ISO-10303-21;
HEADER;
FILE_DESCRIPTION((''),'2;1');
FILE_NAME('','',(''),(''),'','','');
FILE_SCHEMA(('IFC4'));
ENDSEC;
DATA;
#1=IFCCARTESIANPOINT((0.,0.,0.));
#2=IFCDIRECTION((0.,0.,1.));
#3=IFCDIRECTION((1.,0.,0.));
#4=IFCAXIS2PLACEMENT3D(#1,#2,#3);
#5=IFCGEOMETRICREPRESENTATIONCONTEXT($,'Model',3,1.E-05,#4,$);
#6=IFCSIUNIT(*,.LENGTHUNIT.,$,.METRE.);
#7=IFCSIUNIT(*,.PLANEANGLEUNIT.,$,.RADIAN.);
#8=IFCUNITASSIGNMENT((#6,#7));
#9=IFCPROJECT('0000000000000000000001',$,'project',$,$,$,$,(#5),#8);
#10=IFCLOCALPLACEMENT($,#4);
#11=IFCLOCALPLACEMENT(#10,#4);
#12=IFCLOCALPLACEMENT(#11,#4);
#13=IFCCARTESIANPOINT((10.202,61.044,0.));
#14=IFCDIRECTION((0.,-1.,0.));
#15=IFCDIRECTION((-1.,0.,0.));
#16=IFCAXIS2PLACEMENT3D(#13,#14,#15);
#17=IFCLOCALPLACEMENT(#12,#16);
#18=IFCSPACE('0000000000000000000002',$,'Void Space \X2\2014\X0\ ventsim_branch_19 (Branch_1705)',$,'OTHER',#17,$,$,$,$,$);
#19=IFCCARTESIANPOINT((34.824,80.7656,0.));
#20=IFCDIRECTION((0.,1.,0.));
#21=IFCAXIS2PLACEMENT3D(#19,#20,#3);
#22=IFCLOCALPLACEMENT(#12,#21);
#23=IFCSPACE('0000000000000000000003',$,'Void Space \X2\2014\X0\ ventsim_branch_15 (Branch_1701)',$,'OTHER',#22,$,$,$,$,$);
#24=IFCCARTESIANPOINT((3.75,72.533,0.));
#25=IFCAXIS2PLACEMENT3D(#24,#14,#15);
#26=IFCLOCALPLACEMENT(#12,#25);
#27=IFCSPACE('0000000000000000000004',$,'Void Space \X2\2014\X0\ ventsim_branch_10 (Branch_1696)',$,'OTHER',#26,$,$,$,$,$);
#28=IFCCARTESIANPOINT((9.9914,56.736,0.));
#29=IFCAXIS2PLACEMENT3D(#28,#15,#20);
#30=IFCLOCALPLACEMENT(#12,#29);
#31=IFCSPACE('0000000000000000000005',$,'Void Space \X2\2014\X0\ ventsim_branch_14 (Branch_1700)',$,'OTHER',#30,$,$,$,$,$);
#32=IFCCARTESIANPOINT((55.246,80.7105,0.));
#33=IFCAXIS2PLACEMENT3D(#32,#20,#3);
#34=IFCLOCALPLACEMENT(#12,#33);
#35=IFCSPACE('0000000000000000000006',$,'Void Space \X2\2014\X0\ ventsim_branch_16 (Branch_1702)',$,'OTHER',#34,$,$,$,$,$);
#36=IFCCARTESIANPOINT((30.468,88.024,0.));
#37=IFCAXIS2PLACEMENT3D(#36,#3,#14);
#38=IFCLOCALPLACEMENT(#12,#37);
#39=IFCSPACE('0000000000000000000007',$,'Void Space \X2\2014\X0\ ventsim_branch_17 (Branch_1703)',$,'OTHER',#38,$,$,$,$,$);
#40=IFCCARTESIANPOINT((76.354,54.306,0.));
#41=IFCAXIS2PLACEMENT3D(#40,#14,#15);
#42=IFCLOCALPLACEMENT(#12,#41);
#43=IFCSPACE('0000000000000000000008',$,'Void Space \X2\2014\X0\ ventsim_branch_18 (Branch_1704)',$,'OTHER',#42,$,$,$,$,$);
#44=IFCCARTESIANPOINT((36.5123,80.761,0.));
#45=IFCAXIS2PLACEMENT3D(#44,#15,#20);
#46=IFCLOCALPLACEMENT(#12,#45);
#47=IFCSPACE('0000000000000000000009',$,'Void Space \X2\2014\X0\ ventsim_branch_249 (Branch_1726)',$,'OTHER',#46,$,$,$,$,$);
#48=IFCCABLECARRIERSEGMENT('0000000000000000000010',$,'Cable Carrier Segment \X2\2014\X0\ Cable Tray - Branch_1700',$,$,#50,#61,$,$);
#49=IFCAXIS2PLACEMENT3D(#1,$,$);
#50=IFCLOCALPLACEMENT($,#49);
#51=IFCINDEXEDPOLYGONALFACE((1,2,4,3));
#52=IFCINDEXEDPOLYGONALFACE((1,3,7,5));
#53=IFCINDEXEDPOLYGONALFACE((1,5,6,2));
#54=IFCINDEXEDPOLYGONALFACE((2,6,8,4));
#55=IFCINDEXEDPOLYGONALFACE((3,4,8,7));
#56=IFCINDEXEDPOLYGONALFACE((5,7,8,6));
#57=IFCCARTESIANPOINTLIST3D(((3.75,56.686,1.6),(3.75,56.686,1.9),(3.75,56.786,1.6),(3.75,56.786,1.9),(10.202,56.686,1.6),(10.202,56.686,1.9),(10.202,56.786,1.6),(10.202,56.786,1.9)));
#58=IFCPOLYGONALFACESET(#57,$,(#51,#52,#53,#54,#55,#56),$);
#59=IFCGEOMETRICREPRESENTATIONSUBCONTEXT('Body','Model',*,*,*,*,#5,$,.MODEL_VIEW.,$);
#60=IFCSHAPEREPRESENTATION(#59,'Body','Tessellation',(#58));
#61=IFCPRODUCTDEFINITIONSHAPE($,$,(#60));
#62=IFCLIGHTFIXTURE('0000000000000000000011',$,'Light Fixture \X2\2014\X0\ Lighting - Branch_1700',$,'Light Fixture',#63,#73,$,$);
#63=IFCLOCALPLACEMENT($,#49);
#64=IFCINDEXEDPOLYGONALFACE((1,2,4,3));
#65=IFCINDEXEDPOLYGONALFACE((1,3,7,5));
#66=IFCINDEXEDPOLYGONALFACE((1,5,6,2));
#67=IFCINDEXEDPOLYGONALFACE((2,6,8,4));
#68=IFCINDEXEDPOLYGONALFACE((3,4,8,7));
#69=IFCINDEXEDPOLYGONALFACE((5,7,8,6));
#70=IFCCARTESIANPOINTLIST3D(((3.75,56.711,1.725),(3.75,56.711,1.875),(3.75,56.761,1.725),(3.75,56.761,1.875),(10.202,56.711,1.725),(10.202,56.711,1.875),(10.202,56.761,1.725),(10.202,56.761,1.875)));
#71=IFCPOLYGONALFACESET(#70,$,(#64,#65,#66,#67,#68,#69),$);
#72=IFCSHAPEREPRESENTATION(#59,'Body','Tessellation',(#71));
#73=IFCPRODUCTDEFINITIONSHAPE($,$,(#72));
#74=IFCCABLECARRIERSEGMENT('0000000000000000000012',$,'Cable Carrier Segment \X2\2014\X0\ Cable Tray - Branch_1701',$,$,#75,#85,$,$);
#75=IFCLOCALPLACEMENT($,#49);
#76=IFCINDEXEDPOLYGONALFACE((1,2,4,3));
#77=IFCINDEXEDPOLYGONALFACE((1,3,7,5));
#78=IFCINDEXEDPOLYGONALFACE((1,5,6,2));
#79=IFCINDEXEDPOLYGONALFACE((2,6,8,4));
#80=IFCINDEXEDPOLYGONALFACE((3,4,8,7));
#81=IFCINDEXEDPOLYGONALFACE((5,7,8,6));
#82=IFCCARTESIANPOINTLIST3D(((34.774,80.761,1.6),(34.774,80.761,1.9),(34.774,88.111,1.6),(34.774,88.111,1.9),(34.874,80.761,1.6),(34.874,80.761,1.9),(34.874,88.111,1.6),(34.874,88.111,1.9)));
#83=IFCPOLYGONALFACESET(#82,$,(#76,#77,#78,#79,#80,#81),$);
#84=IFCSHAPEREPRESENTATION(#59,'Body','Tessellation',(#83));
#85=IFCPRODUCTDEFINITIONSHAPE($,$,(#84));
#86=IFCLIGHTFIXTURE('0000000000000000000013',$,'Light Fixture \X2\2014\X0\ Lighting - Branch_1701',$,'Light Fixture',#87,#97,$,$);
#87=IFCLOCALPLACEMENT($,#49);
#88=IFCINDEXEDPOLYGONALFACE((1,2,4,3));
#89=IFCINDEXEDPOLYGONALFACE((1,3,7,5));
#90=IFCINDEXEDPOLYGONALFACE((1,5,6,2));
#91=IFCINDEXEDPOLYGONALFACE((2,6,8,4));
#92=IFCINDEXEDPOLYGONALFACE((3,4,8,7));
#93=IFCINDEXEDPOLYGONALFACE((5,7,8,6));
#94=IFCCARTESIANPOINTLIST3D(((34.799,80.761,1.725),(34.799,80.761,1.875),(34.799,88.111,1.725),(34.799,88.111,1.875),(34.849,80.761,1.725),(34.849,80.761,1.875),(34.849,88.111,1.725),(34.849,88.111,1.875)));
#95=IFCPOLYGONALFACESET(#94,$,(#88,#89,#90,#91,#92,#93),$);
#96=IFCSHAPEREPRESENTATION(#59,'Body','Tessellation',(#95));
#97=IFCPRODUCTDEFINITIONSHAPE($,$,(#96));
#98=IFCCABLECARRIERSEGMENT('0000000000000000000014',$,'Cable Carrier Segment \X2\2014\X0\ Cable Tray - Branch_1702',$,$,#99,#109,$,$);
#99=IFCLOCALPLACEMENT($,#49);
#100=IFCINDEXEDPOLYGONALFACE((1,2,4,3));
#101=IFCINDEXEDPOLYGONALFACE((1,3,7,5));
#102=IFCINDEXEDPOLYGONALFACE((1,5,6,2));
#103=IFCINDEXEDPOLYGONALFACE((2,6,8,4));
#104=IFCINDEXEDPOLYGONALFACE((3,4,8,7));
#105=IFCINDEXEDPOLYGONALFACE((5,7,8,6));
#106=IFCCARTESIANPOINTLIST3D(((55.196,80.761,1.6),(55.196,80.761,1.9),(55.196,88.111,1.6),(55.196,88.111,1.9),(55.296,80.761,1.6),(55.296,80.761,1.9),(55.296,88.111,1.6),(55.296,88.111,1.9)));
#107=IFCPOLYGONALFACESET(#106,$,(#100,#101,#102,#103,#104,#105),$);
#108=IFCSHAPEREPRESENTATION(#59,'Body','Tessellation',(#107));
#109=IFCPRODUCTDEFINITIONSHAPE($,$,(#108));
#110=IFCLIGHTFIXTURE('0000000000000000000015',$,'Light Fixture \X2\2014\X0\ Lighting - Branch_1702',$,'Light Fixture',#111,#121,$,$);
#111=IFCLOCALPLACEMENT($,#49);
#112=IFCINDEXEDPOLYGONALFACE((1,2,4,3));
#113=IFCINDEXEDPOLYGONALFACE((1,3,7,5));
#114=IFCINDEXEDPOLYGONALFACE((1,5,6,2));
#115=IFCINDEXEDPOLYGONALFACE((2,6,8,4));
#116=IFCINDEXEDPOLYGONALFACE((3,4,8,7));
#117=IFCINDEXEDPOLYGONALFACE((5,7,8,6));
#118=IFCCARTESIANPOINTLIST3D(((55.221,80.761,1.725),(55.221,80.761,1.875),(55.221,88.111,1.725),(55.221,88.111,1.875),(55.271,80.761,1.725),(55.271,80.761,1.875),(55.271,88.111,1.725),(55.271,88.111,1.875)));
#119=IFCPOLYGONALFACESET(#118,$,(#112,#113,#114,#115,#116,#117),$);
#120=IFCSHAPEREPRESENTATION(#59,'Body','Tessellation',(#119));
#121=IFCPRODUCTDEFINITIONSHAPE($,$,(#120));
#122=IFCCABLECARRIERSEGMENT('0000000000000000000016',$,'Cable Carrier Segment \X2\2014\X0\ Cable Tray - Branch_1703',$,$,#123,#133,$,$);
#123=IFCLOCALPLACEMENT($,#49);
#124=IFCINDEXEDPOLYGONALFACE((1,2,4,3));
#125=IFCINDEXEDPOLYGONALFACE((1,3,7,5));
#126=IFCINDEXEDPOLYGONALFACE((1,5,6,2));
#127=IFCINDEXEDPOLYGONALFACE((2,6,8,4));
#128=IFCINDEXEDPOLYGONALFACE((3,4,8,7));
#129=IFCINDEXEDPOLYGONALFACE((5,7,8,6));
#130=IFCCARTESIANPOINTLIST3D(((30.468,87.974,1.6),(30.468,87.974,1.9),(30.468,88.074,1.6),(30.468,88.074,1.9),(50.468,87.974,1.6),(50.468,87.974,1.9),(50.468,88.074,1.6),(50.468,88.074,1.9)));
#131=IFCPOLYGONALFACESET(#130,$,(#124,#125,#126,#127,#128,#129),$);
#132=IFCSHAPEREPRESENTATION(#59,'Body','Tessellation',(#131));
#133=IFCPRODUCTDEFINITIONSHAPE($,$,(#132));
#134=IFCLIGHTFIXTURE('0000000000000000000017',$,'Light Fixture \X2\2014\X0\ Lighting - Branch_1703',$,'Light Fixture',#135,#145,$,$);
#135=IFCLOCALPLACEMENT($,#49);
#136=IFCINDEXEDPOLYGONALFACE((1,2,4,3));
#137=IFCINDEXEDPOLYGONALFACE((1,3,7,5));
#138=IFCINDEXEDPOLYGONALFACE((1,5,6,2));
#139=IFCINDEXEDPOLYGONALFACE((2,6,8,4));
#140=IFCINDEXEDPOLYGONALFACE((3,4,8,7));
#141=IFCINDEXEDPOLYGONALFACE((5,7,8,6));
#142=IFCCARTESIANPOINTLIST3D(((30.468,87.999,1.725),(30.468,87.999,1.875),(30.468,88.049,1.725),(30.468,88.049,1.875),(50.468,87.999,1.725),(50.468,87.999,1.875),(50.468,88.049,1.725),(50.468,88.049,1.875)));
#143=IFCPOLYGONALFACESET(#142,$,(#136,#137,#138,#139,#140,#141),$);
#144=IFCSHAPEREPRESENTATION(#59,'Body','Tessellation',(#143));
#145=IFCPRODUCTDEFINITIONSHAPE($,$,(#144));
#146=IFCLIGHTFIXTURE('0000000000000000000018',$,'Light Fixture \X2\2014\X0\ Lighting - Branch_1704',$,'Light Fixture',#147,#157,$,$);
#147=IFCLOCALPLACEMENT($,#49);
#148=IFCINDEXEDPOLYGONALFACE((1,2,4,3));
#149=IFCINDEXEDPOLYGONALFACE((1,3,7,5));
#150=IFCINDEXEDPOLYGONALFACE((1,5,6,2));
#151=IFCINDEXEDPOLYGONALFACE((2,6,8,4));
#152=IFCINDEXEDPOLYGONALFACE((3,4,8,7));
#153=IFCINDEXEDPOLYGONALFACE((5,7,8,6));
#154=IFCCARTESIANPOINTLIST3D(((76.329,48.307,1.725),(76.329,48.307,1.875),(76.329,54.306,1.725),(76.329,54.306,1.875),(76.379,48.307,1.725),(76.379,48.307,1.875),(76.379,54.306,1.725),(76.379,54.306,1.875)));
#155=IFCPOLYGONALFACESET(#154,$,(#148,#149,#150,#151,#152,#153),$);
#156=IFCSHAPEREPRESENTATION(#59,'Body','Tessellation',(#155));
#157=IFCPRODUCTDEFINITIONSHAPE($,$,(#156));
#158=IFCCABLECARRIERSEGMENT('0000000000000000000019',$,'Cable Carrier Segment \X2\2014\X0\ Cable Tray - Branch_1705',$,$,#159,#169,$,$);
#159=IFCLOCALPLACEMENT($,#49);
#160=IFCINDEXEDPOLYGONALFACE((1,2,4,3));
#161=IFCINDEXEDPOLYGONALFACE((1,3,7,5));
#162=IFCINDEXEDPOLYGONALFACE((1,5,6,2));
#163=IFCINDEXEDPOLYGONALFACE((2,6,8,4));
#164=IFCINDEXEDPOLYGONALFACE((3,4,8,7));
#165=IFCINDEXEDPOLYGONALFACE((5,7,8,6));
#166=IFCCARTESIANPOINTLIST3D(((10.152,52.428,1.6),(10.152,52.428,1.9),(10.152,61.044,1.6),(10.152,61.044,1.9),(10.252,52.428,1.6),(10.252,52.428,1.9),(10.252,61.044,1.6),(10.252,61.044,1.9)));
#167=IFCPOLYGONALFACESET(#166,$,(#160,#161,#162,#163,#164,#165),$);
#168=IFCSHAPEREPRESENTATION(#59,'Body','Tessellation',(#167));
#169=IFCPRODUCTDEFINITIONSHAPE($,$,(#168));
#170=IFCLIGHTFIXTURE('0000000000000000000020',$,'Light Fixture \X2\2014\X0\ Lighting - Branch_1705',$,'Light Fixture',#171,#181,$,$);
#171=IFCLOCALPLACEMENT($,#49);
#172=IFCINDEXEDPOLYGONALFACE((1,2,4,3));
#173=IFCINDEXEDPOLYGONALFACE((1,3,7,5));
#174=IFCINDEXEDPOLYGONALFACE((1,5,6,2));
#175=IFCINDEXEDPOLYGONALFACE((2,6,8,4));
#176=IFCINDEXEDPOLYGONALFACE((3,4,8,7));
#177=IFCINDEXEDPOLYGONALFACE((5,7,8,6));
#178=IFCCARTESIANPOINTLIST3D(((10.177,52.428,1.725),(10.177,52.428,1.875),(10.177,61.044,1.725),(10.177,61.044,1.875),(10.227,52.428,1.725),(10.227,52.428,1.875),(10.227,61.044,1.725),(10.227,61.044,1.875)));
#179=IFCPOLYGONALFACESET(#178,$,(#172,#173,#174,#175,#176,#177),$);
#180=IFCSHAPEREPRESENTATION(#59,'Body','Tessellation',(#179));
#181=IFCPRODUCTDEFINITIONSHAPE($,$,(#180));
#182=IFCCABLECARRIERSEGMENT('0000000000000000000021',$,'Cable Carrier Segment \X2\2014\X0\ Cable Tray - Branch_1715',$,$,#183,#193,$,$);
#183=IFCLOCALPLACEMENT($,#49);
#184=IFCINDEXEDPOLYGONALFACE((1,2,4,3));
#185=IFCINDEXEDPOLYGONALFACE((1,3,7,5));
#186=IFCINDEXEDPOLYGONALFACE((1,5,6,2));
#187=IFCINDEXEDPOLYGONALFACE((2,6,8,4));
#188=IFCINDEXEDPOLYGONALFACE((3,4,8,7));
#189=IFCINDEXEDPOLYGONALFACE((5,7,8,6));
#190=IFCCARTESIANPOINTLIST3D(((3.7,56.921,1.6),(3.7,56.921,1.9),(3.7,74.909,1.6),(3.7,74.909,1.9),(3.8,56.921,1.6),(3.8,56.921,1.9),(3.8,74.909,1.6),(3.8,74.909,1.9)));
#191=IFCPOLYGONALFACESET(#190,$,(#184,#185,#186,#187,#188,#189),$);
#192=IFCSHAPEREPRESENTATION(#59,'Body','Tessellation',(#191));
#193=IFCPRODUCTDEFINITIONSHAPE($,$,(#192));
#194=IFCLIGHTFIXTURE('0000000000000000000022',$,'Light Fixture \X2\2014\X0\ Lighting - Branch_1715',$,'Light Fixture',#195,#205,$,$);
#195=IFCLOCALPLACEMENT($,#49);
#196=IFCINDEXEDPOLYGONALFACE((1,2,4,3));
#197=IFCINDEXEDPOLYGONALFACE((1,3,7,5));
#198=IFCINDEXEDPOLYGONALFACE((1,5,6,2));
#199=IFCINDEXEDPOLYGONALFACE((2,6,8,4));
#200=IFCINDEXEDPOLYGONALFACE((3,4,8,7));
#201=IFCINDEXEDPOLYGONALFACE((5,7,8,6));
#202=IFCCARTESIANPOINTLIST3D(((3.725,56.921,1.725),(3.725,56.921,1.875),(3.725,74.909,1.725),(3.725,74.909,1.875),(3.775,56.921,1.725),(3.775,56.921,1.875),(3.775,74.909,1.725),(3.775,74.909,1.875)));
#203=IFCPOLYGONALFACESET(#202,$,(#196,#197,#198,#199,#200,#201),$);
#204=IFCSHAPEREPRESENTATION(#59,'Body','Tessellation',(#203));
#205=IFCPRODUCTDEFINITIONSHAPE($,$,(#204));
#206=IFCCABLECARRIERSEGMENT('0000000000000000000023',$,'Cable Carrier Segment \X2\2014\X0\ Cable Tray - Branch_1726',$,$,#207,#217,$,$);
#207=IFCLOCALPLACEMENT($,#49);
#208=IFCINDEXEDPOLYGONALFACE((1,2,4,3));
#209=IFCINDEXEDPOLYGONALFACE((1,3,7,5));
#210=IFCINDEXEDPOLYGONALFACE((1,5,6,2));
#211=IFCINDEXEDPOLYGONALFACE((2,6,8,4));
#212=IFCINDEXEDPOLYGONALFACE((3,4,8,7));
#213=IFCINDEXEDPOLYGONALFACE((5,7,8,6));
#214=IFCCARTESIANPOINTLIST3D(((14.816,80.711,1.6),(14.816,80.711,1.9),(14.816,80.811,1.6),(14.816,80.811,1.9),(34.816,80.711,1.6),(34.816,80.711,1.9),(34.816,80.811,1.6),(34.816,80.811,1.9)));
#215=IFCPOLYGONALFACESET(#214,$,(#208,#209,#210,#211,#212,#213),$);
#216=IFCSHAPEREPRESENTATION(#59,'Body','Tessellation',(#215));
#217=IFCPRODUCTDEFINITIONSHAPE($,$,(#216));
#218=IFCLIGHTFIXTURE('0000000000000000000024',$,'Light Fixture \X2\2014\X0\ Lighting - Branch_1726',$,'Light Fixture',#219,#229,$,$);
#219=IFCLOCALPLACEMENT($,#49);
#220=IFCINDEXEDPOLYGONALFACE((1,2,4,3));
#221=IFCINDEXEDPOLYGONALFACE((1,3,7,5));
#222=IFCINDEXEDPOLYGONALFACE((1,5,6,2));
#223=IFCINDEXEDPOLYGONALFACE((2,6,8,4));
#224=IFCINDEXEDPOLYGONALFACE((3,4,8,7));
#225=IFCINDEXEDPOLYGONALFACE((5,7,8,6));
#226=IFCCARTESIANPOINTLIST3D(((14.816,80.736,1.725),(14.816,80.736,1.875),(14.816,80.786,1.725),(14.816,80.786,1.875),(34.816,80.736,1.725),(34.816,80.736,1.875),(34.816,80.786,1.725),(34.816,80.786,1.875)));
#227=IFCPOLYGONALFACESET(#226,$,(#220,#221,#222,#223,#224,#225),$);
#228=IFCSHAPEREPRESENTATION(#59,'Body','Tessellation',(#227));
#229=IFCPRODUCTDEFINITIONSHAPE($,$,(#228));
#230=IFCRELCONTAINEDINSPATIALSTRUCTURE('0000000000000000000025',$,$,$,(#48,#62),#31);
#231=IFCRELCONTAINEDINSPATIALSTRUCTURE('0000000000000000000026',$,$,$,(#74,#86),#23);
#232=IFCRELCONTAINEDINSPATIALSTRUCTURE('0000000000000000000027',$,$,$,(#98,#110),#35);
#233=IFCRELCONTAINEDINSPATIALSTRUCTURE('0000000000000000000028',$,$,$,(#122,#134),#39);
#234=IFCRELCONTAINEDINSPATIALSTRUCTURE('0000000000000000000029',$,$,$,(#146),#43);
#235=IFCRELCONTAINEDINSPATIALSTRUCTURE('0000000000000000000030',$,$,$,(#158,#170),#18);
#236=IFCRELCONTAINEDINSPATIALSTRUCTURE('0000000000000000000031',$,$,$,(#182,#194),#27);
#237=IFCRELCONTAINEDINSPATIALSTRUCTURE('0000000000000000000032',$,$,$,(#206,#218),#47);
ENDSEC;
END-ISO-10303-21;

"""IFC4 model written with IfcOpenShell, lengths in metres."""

from ifc_helpers import new_model, si_unit, frame, origin_with_axes, origin_2d_with_axis, place, context, subcontext, project, spatial, rectangle, extrude, element, save


model = new_model("IFC4")

# Units and contexts
model_context = context("Model", 3, precision=1e-05, world=origin_with_axes())
body_context = subcontext(model_context, "Body", "Model", "MODEL_VIEW")
ifc_project = project(units=[si_unit("LENGTHUNIT", "METRE"), si_unit("PLANEANGLEUNIT", "RADIAN")], contexts=[model_context])

# Space
placement_1 = place(None, origin_with_axes())
placement_2 = place(placement_1, origin_with_axes())
placement_3 = place(placement_2, origin_with_axes())
space_1_placement = place(placement_3, frame((10.202, 61.044, 0.0), z_axis=(0.0, -1.0, 0.0), x_axis=(-1.0, 0.0, 0.0)))
space_1 = spatial("IfcSpace", at=space_1_placement, Name="Void Space — ventsim_branch_19 (Branch_1705)", ObjectType="OTHER")

# Shared definitions
space_2_placement = place(placement_3, frame((34.824, 80.7656, 0.0), z_axis=(0.0, 1.0, 0.0), x_axis=(1.0, 0.0, 0.0)))
space_2 = spatial("IfcSpace", at=space_2_placement, Name="Void Space — ventsim_branch_15 (Branch_1701)", ObjectType="OTHER")

# Shared definitions
space_3_placement = place(placement_3, frame((3.75, 72.533, 0.0), z_axis=(0.0, -1.0, 0.0), x_axis=(-1.0, 0.0, 0.0)))
space_3 = spatial("IfcSpace", at=space_3_placement, Name="Void Space — ventsim_branch_10 (Branch_1696)", ObjectType="OTHER")

# Shared definitions
space_4_placement = place(placement_3, frame((9.9914, 56.736, 0.0), z_axis=(-1.0, 0.0, 0.0), x_axis=(0.0, 1.0, 0.0)))
space_4 = spatial("IfcSpace", at=space_4_placement, Name="Void Space — ventsim_branch_14 (Branch_1700)", ObjectType="OTHER")

# Cable carrier segment
cable_carrier_segment_1_placement = place(placement_3, frame((10.202, 56.736, 1.75), z_axis=(-1.0, 0.0, 0.0), x_axis=(0.0, 0.0, 1.0)))
element("IfcCableCarrierSegment", 1, at=cable_carrier_segment_1_placement, inside=space_4, Name="Cable Carrier Segment — Cable Tray - Branch_1700", context=body_context, shape_type="SweptSolid", body=[
    extrude(rectangle(XDim=0.3, YDim=0.1, at=origin_2d_with_axis()), origin_with_axes(), (0.0, 0.0, 1.0), 6.452),
])

# Light fixture
light_fixture_1_placement = place(placement_3, frame((10.202, 56.736, 1.8), z_axis=(-1.0, 0.0, 0.0), x_axis=(0.0, 0.0, 1.0)))
element("IfcLightFixture", 2, at=light_fixture_1_placement, inside=space_4, Name="Light Fixture — Lighting - Branch_1700", ObjectType="Light Fixture", context=body_context, shape_type="SweptSolid", body=[
    extrude(rectangle(XDim=0.15, YDim=0.05, at=origin_2d_with_axis()), origin_with_axes(), (0.0, 0.0, 1.0), 6.452),
])

# Cable carrier segment
cable_carrier_segment_2_placement = place(placement_3, frame((34.824, 80.761, 1.75), z_axis=(0.0, 1.0, 0.0), x_axis=(0.0, 0.0, 1.0)))
element("IfcCableCarrierSegment", 3, at=cable_carrier_segment_2_placement, inside=space_2, Name="Cable Carrier Segment — Cable Tray - Branch_1701", context=body_context, shape_type="SweptSolid", body=[
    extrude(rectangle(XDim=0.3, YDim=0.1, at=origin_2d_with_axis()), origin_with_axes(), (0.0, 0.0, 1.0), 7.35),
])

# Light fixture
light_fixture_2_placement = place(placement_3, frame((34.824, 80.761, 1.8), z_axis=(0.0, 1.0, 0.0), x_axis=(0.0, 0.0, 1.0)))
element("IfcLightFixture", 4, at=light_fixture_2_placement, inside=space_2, Name="Light Fixture — Lighting - Branch_1701", ObjectType="Light Fixture", context=body_context, shape_type="SweptSolid", body=[
    extrude(rectangle(XDim=0.15, YDim=0.05, at=origin_2d_with_axis()), origin_with_axes(), (0.0, 0.0, 1.0), 7.35),
])

# Shared definitions
space_5_placement = place(placement_3, frame((55.246, 80.7105, 0.0), z_axis=(0.0, 1.0, 0.0), x_axis=(1.0, 0.0, 0.0)))
space_5 = spatial("IfcSpace", at=space_5_placement, Name="Void Space — ventsim_branch_16 (Branch_1702)", ObjectType="OTHER")

# Cable carrier segment
cable_carrier_segment_3_placement = place(placement_3, frame((55.246, 80.761, 1.75), z_axis=(0.0, 1.0, 0.0), x_axis=(0.0, 0.0, 1.0)))
element("IfcCableCarrierSegment", 5, at=cable_carrier_segment_3_placement, inside=space_5, Name="Cable Carrier Segment — Cable Tray - Branch_1702", context=body_context, shape_type="SweptSolid", body=[
    extrude(rectangle(XDim=0.3, YDim=0.1, at=origin_2d_with_axis()), origin_with_axes(), (0.0, 0.0, 1.0), 7.35),
])

# Light fixture
light_fixture_3_placement = place(placement_3, frame((55.246, 80.761, 1.8), z_axis=(0.0, 1.0, 0.0), x_axis=(0.0, 0.0, 1.0)))
element("IfcLightFixture", 6, at=light_fixture_3_placement, inside=space_5, Name="Light Fixture — Lighting - Branch_1702", ObjectType="Light Fixture", context=body_context, shape_type="SweptSolid", body=[
    extrude(rectangle(XDim=0.15, YDim=0.05, at=origin_2d_with_axis()), origin_with_axes(), (0.0, 0.0, 1.0), 7.35),
])

# Shared definitions
space_6_placement = place(placement_3, frame((30.468, 88.024, 0.0), z_axis=(1.0, 0.0, 0.0), x_axis=(0.0, -1.0, 0.0)))
space_6 = spatial("IfcSpace", at=space_6_placement, Name="Void Space — ventsim_branch_17 (Branch_1703)", ObjectType="OTHER")

# Cable carrier segment
cable_carrier_segment_4_placement = place(placement_3, frame((30.468, 88.024, 1.75), z_axis=(1.0, 0.0, 0.0), x_axis=(0.0, 0.0, 1.0)))
element("IfcCableCarrierSegment", 7, at=cable_carrier_segment_4_placement, inside=space_6, Name="Cable Carrier Segment — Cable Tray - Branch_1703", context=body_context, shape_type="SweptSolid", body=[
    extrude(rectangle(XDim=0.3, YDim=0.1, at=origin_2d_with_axis()), origin_with_axes(), (0.0, 0.0, 1.0), 20.0),
])

# Light fixture
light_fixture_4_placement = place(placement_3, frame((30.468, 88.024, 1.8), z_axis=(1.0, 0.0, 0.0), x_axis=(0.0, 0.0, 1.0)))
element("IfcLightFixture", 8, at=light_fixture_4_placement, inside=space_6, Name="Light Fixture — Lighting - Branch_1703", ObjectType="Light Fixture", context=body_context, shape_type="SweptSolid", body=[
    extrude(rectangle(XDim=0.15, YDim=0.05, at=origin_2d_with_axis()), origin_with_axes(), (0.0, 0.0, 1.0), 20.0),
])

# Shared definitions
space_7_placement = place(placement_3, frame((76.354, 54.306, 0.0), z_axis=(0.0, -1.0, 0.0), x_axis=(-1.0, 0.0, 0.0)))
space_7 = spatial("IfcSpace", at=space_7_placement, Name="Void Space — ventsim_branch_18 (Branch_1704)", ObjectType="OTHER")

# Light fixture
light_fixture_5_placement = place(placement_3, frame((76.354, 54.306, 1.8), z_axis=(0.0, -1.0, 0.0), x_axis=(0.0, 0.0, 1.0)))
element("IfcLightFixture", 9, at=light_fixture_5_placement, inside=space_7, Name="Light Fixture — Lighting - Branch_1704", ObjectType="Light Fixture", context=body_context, shape_type="SweptSolid", body=[
    extrude(rectangle(XDim=0.15, YDim=0.05, at=origin_2d_with_axis()), origin_with_axes(), (0.0, 0.0, 1.0), 5.999),
])

# Cable carrier segment
cable_carrier_segment_5_placement = place(placement_3, frame((10.202, 61.044, 1.75), z_axis=(0.0, -1.0, 0.0), x_axis=(0.0, 0.0, 1.0)))
element("IfcCableCarrierSegment", 10, at=cable_carrier_segment_5_placement, inside=space_1, Name="Cable Carrier Segment — Cable Tray - Branch_1705", context=body_context, shape_type="SweptSolid", body=[
    extrude(rectangle(XDim=0.3, YDim=0.1, at=origin_2d_with_axis()), origin_with_axes(), (0.0, 0.0, 1.0), 8.616),
])

# Light fixture
light_fixture_6_placement = place(placement_3, frame((10.202, 61.044, 1.8), z_axis=(0.0, -1.0, 0.0), x_axis=(0.0, 0.0, 1.0)))
element("IfcLightFixture", 11, at=light_fixture_6_placement, inside=space_1, Name="Light Fixture — Lighting - Branch_1705", ObjectType="Light Fixture", context=body_context, shape_type="SweptSolid", body=[
    extrude(rectangle(XDim=0.15, YDim=0.05, at=origin_2d_with_axis()), origin_with_axes(), (0.0, 0.0, 1.0), 8.616),
])

# Cable carrier segment
cable_carrier_segment_6_placement = place(placement_3, frame((3.75, 74.909, 1.75), z_axis=(0.0, -1.0, 0.0), x_axis=(0.0, 0.0, 1.0)))
element("IfcCableCarrierSegment", 12, at=cable_carrier_segment_6_placement, inside=space_3, Name="Cable Carrier Segment — Cable Tray - Branch_1715", context=body_context, shape_type="SweptSolid", body=[
    extrude(rectangle(XDim=0.3, YDim=0.1, at=origin_2d_with_axis()), origin_with_axes(), (0.0, 0.0, 1.0), 17.988),
])

# Light fixture
light_fixture_7_placement = place(placement_3, frame((3.75, 74.909, 1.8), z_axis=(0.0, -1.0, 0.0), x_axis=(0.0, 0.0, 1.0)))
element("IfcLightFixture", 13, at=light_fixture_7_placement, inside=space_3, Name="Light Fixture — Lighting - Branch_1715", ObjectType="Light Fixture", context=body_context, shape_type="SweptSolid", body=[
    extrude(rectangle(XDim=0.15, YDim=0.05, at=origin_2d_with_axis()), origin_with_axes(), (0.0, 0.0, 1.0), 17.988),
])

# Shared definitions
space_8_placement = place(placement_3, frame((36.5123, 80.761, 0.0), z_axis=(-1.0, 0.0, 0.0), x_axis=(0.0, 1.0, 0.0)))
space_8 = spatial("IfcSpace", at=space_8_placement, Name="Void Space — ventsim_branch_249 (Branch_1726)", ObjectType="OTHER")

# Cable carrier segment
cable_carrier_segment_7_placement = place(placement_3, frame((34.816, 80.761, 1.75), z_axis=(-1.0, 0.0, 0.0), x_axis=(0.0, 0.0, 1.0)))
element("IfcCableCarrierSegment", 14, at=cable_carrier_segment_7_placement, inside=space_8, Name="Cable Carrier Segment — Cable Tray - Branch_1726", context=body_context, shape_type="SweptSolid", body=[
    extrude(rectangle(XDim=0.3, YDim=0.1, at=origin_2d_with_axis()), origin_with_axes(), (0.0, 0.0, 1.0), 20.0),
])

# Light fixture
light_fixture_8_placement = place(placement_3, frame((34.816, 80.761, 1.8), z_axis=(-1.0, 0.0, 0.0), x_axis=(0.0, 0.0, 1.0)))
element("IfcLightFixture", 15, at=light_fixture_8_placement, inside=space_8, Name="Light Fixture — Lighting - Branch_1726", ObjectType="Light Fixture", context=body_context, shape_type="SweptSolid", body=[
    extrude(rectangle(XDim=0.15, YDim=0.05, at=origin_2d_with_axis()), origin_with_axes(), (0.0, 0.0, 1.0), 20.0),
])

save(model, "model.ifc")
